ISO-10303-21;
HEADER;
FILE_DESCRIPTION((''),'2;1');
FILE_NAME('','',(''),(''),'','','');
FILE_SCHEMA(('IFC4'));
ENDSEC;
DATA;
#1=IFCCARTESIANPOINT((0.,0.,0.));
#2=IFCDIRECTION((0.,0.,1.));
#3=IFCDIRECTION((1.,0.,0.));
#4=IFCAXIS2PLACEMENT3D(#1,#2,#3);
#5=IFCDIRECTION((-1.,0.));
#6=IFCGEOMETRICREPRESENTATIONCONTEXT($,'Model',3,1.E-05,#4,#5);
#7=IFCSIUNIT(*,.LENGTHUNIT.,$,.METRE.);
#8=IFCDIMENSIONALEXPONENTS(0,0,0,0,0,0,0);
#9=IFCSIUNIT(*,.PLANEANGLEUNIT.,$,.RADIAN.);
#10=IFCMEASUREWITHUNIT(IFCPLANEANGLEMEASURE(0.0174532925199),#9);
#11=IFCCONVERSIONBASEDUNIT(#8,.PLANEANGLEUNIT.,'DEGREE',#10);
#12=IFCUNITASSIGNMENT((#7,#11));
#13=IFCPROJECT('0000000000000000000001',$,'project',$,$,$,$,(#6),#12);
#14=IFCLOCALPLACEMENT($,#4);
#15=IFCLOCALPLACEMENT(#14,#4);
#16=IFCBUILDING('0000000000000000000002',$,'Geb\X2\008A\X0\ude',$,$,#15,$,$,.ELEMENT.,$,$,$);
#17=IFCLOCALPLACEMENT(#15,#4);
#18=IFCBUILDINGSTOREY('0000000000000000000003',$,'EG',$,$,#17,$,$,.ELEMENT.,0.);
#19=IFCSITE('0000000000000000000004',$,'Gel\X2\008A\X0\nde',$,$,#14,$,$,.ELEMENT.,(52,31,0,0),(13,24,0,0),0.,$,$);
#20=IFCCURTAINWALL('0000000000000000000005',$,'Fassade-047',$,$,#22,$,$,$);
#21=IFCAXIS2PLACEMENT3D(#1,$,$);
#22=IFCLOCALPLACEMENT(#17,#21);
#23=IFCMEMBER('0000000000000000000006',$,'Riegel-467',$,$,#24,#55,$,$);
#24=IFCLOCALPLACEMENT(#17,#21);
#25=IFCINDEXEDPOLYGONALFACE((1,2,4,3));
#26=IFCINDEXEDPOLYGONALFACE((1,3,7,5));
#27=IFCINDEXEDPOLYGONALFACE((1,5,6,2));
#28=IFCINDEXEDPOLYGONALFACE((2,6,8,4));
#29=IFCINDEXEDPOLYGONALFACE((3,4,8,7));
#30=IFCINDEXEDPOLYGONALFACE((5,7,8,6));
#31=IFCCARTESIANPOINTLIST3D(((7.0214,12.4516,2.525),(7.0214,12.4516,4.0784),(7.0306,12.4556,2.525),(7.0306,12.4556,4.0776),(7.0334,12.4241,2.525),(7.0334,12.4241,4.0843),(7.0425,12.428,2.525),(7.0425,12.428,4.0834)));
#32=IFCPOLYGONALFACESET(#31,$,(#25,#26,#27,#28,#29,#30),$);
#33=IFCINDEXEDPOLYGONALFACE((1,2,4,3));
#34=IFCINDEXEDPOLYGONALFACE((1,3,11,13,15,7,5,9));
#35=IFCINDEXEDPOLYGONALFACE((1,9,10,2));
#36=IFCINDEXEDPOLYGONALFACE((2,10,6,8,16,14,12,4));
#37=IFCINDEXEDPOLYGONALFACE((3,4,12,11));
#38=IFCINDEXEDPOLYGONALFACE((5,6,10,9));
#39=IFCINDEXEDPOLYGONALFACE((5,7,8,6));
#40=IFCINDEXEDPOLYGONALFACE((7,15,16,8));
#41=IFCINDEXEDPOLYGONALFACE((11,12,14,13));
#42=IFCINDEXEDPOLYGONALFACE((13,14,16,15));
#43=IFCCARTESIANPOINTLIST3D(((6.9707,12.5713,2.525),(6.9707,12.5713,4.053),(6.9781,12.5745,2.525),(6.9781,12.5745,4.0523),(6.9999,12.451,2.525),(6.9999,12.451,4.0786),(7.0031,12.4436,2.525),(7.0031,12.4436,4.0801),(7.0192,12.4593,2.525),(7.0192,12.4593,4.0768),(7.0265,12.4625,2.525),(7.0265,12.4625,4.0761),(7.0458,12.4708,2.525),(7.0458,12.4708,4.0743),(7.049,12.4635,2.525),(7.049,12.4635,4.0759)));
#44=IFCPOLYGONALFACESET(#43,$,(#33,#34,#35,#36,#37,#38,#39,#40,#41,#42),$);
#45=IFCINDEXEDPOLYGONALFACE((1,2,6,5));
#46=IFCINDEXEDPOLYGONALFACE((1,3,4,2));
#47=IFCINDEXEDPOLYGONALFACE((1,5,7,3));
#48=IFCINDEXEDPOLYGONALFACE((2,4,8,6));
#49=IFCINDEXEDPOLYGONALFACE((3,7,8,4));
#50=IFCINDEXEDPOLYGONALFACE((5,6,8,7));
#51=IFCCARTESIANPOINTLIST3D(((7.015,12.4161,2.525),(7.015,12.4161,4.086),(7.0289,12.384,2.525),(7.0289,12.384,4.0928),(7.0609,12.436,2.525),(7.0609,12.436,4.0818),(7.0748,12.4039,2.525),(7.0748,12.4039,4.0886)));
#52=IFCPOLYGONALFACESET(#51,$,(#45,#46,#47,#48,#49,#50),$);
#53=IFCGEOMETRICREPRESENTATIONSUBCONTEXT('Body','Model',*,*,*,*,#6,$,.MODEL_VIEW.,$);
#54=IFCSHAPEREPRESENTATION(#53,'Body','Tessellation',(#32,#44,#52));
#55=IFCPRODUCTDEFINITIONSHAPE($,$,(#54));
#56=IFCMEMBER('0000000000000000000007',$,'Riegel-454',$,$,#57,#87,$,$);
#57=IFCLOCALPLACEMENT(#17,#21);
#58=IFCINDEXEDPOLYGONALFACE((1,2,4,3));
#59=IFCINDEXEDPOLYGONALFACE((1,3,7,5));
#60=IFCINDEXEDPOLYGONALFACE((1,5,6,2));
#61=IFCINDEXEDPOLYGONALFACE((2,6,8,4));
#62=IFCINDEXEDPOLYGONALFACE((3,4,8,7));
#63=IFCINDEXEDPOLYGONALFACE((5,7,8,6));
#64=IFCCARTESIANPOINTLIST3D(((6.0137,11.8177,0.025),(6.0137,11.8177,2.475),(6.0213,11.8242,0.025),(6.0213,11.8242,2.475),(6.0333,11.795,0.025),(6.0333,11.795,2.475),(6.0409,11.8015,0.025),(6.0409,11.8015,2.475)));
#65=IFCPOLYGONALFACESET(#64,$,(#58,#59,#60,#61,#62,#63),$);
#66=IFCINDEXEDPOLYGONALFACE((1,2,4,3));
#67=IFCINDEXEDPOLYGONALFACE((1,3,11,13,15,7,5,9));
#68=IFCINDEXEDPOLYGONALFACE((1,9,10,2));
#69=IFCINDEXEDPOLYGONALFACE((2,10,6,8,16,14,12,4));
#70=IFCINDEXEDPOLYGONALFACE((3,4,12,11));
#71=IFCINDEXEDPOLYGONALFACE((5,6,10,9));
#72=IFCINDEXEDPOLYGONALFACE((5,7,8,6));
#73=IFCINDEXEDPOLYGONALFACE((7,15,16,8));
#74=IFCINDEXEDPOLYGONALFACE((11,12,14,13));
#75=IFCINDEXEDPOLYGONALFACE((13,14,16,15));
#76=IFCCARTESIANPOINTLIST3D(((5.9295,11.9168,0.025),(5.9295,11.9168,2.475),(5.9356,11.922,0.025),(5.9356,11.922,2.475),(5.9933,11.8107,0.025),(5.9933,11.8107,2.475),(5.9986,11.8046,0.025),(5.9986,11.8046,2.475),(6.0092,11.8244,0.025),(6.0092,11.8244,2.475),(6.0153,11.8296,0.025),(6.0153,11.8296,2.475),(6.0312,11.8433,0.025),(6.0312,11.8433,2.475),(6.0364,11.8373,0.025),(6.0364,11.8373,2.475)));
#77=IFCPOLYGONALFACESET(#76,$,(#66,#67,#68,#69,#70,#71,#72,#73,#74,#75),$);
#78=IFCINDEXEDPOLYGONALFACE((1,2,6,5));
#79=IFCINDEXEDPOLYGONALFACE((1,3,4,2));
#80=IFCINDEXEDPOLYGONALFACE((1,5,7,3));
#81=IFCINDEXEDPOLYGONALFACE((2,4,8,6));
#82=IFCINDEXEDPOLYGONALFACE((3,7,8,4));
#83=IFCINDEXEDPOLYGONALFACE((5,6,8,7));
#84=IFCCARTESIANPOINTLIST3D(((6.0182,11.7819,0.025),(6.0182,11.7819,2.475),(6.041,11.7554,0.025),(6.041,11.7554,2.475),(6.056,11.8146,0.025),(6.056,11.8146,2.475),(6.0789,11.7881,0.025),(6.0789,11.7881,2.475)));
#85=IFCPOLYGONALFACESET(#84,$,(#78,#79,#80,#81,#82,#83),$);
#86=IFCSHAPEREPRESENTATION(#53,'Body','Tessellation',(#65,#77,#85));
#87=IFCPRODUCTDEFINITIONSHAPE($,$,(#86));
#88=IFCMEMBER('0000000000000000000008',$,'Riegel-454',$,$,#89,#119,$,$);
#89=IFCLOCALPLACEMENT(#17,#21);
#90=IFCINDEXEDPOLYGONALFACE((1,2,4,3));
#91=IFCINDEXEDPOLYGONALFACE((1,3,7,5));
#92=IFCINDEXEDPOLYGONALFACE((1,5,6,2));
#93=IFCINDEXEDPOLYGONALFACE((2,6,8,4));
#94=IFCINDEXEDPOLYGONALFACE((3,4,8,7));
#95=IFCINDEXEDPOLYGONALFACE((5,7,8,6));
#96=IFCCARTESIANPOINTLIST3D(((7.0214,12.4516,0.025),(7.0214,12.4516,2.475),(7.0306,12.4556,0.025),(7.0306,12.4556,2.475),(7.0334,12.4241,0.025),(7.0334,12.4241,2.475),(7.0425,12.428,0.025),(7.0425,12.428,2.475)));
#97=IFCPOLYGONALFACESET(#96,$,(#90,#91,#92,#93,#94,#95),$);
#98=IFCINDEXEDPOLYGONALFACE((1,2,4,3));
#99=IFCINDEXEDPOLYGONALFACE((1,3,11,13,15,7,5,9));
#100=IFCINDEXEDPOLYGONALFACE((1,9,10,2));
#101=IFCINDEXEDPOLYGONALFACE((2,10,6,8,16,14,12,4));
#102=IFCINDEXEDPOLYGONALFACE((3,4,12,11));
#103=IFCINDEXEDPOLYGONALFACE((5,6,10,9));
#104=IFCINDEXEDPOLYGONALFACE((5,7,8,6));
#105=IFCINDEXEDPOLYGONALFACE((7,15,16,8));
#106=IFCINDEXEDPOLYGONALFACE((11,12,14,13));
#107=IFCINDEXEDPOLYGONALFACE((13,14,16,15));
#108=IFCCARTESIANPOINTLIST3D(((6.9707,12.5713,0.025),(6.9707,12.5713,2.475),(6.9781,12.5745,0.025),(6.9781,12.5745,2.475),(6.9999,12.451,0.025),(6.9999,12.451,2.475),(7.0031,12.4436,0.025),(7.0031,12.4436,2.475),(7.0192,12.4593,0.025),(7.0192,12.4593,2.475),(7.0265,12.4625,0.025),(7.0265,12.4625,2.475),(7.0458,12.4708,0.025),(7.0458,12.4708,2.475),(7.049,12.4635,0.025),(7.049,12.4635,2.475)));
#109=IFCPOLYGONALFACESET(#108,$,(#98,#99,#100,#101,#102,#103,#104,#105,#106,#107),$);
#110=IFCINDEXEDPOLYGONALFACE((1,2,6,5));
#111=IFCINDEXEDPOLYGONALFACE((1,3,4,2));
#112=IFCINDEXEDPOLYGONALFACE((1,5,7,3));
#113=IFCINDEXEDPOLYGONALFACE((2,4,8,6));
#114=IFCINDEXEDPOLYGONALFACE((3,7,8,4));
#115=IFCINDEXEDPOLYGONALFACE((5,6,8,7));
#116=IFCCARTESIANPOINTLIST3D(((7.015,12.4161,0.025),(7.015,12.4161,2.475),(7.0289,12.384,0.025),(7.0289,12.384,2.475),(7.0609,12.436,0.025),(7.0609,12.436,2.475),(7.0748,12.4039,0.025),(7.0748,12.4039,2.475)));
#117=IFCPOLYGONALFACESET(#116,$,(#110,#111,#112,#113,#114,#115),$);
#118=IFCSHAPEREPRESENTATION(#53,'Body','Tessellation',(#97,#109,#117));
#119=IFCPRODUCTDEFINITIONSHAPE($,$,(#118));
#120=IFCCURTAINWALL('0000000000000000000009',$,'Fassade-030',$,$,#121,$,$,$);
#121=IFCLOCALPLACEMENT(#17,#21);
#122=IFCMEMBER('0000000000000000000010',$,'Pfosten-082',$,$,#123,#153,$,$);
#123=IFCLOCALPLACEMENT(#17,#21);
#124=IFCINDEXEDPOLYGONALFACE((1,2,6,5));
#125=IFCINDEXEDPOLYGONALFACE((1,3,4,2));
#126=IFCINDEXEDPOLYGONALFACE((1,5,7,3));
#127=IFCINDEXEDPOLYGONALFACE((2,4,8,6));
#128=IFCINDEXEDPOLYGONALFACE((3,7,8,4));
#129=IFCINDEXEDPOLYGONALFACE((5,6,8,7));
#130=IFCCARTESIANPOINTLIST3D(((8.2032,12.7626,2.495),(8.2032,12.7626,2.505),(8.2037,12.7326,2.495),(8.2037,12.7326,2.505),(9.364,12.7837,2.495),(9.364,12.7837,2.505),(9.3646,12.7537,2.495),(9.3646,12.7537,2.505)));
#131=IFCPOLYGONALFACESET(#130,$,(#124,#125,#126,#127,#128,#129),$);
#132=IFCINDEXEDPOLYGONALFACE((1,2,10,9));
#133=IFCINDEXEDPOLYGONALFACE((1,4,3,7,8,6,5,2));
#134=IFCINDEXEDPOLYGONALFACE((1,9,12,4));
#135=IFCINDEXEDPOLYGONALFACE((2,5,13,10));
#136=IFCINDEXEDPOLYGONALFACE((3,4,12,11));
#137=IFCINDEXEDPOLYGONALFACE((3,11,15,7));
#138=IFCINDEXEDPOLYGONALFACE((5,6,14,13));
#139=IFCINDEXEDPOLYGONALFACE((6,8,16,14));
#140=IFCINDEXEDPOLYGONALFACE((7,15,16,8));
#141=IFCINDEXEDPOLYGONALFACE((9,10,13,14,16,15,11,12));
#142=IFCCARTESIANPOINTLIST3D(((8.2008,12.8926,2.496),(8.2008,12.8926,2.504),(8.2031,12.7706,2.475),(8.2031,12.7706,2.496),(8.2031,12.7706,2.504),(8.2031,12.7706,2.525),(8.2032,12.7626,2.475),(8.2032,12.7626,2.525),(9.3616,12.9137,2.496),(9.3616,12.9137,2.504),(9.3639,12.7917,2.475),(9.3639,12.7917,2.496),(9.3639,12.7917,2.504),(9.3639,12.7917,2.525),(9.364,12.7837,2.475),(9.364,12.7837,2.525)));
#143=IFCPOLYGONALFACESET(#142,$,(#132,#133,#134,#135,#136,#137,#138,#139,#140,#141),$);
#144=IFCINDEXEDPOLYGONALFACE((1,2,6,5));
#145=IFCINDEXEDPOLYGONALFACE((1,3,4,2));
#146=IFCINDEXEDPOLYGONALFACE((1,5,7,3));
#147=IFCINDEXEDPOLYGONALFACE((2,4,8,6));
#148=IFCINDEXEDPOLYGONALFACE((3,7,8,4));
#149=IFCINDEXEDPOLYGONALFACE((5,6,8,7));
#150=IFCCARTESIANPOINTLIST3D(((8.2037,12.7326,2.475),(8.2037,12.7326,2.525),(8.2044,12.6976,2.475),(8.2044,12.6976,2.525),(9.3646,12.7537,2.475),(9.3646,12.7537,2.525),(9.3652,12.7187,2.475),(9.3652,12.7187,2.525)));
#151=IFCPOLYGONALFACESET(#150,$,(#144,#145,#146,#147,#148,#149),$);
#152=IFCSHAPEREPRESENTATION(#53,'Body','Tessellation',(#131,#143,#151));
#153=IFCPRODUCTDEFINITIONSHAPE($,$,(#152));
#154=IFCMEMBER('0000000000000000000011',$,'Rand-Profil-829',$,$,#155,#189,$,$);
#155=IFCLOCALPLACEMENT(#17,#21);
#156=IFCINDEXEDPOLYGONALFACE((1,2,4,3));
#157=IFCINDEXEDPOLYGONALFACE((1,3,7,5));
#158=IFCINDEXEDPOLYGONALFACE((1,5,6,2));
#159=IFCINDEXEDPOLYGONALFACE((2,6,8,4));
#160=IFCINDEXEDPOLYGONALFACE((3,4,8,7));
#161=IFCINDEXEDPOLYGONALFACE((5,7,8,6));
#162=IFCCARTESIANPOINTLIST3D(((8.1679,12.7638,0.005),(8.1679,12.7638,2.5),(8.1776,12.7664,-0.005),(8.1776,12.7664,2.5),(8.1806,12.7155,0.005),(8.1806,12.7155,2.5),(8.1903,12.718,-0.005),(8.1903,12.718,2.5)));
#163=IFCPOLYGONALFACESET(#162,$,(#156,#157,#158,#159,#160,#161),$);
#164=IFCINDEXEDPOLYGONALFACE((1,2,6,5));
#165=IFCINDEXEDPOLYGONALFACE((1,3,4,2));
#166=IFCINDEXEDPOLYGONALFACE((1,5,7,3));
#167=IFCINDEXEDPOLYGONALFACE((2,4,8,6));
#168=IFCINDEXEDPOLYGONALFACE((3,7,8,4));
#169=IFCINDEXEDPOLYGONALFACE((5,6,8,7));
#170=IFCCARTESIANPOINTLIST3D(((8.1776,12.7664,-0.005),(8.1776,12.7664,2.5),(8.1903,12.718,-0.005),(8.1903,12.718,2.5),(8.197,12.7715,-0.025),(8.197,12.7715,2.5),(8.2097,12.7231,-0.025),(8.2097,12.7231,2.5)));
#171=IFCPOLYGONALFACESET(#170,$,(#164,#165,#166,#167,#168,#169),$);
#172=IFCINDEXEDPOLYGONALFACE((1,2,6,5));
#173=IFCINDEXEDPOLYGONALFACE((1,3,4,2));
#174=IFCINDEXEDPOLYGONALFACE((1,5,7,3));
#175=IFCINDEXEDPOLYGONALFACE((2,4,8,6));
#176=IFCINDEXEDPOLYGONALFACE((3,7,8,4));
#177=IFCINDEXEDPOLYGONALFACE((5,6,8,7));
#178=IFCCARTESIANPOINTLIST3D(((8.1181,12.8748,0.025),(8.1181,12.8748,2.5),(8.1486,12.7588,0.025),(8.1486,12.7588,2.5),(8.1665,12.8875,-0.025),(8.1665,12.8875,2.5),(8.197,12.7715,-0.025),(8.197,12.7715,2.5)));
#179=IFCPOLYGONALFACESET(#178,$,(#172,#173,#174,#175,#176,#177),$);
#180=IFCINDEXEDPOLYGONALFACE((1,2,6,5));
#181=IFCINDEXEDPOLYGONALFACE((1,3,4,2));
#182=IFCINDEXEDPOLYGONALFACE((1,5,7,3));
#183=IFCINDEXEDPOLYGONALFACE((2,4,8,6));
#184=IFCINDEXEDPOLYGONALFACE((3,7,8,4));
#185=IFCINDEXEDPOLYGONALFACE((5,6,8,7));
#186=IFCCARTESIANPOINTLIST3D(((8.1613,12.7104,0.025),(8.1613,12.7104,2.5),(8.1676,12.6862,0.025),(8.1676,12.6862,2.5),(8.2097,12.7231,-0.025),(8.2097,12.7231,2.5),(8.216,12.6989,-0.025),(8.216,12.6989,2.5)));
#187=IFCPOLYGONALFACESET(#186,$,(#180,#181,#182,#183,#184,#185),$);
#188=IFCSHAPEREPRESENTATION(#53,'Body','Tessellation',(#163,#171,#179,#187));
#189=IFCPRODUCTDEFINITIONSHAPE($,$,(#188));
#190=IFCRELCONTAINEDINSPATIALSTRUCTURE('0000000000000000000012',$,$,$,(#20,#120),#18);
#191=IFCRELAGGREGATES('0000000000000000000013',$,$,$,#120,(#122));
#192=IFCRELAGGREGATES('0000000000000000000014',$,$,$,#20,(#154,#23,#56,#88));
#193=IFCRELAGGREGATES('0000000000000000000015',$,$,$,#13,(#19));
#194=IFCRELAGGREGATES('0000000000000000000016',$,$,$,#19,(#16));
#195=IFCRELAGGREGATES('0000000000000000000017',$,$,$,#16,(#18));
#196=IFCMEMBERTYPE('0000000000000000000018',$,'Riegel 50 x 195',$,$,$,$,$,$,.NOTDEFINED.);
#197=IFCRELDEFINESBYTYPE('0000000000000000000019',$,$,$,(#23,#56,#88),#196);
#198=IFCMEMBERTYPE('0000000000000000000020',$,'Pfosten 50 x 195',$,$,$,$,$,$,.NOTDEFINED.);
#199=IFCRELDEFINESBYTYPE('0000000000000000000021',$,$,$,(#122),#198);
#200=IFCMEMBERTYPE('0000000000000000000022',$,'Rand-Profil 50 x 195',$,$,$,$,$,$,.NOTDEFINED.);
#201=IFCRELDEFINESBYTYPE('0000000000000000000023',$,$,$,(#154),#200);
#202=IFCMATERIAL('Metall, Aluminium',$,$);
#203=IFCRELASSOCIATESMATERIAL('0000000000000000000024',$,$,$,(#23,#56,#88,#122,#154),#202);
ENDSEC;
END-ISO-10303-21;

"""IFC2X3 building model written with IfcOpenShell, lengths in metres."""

from ifc_helpers import new_model, entity, si_unit, converted_unit, direction, frame, origin_with_axes, place, context, subcontext, project, spatial, polyline, outline, extrude, clip, halfspace, material, type_object, element, aggregate, save


model = new_model("IFC2X3")

# Units and contexts
model_context = context("Model", 3, precision=1e-05, world=origin_with_axes(), true_north=direction((-1.0, 0.0)))
body_context = subcontext(model_context, "Body", "Model", "MODEL_VIEW")
ifc_project = project(units=[si_unit("LENGTHUNIT", "METRE"), converted_unit("PLANEANGLEUNIT", "DEGREE", entity("IfcPlaneAngleMeasure", 0.0174532925199), si_unit("PLANEANGLEUNIT", "RADIAN"), dimensions=[0, 0, 0, 0, 0, 0, 0])], contexts=[model_context])

# Site, building, storey
site_placement = place(None, origin_with_axes())
site = spatial("IfcSite", under=ifc_project, at=site_placement, Name="Gel\u008ande", CompositionType="ELEMENT", RefLatitude=(52, 31, 0, 0), RefLongitude=(13, 24, 0, 0), RefElevation=0.0)
building_placement = place(site_placement, origin_with_axes())
building = spatial("IfcBuilding", under=site, at=building_placement, Name="Geb\u008aude", CompositionType="ELEMENT")
storey_placement = place(building_placement, origin_with_axes())
storey = spatial("IfcBuildingStorey", under=building, at=storey_placement, Name="EG", CompositionType="ELEMENT", Elevation=0.0)

# Curtain wall, members
curtain_wall_1_placement = place(storey_placement, frame((7.6056, 12.5904, 0.0), z_axis=(0.0, 0.0, 1.0), x_axis=(1.0, 0.0, 0.0)))
curtain_wall_1 = element("IfcCurtainWall", 1, at=curtain_wall_1_placement, inside=storey, Name="Fassade-047")
ifc_material_1 = material(Name="Metall, Aluminium")
member_type_1 = type_object("IfcMemberType", Name="Riegel 50 x 195", PredefinedType="NOTDEFINED")
member_1_placement = place(curtain_wall_1_placement, frame((-0.5736, -0.1506, 2.5), z_axis=(0.0, 0.0, 1.0), x_axis=(0.917733, 0.397197, 0.0)))
member_1 = element("IfcMember", 2, at=member_1_placement, type_object=member_type_1, material=ifc_material_1, Name="Riegel-467", context=body_context, shape_type="Clipping", body=[
    clip(extrude(outline(polyline([(0.0105, -0.0118), (-0.0014, 0.0158), (-0.0105, 0.0118), (0.0014, -0.0158), (0.0105, -0.0118)])), frame((0.0, 0.0, 0.025), z_axis=(0.0, 0.0, 1.0), x_axis=(0.917733, -0.397197, 0.0)), (0.0, 0.0, 1.0), 1.5593), halfspace(frame((0.1277, 0.2951, 1.5126), z_axis=(-0.082582, -0.190807, -0.978148), x_axis=(0.0, -0.9815, 0.191461)), True)),
    clip(extrude(outline(polyline([(0.017, 0.0237), (0.0138, 0.031), (-0.0055, 0.0227), (-0.0539, 0.1347), (-0.0613, 0.1315), (-0.0128, 0.0195), (-0.0321, 0.0112), (-0.0289, 0.0038), (0.017, 0.0237)])), frame((0.0, 0.0, 0.025), z_axis=(0.0, 0.0, 1.0), x_axis=(0.917733, -0.397197, 0.0)), (0.0, 0.0, 1.0), 1.5551), halfspace(frame((0.1277, 0.2951, 1.5126), z_axis=(-0.082582, -0.190807, -0.978148), x_axis=(0.0, -0.9815, 0.191461)), True)),
    clip(extrude(outline(polyline([(0.0428, -0.036), (0.0289, -0.0038), (-0.017, -0.0237), (-0.0031, -0.0558), (0.0428, -0.036)])), frame((0.0, 0.0, 0.025), z_axis=(0.0, 0.0, 1.0), x_axis=(0.917733, -0.397197, 0.0)), (0.0, 0.0, 1.0), 1.5678), halfspace(frame((0.1277, 0.2951, 1.5126), z_axis=(-0.082582, -0.190807, -0.978148), x_axis=(0.0, -0.9815, 0.191461)), True)),
])
member_2_placement = place(curtain_wall_1_placement, frame((-1.5783, -0.7808, 0.0), z_axis=(0.0, 0.0, 1.0), x_axis=(0.757068, 0.653336, 0.0)))
member_2 = element("IfcMember", 3, at=member_2_placement, type_object=member_type_1, material=ifc_material_1, Name="Riegel-454", context=body_context, shape_type="SweptSolid", body=[
    extrude(outline(polyline([(-0.006, 0.0146), (-0.0136, 0.0081), (0.006, -0.0146), (0.0136, -0.0081), (-0.006, 0.0146)])), frame((0.0, 0.0, 0.025), z_axis=(0.0, 0.0, 1.0), x_axis=(0.757068, -0.653336, 0.0)), (0.0, 0.0, 1.0), 2.45),
    extrude(outline(polyline([(-0.0917, 0.1124), (-0.0978, 0.1072), (-0.0181, 0.0148), (-0.034, 0.0011), (-0.0287, -0.005), (0.0091, 0.0277), (0.0039, 0.0337), (-0.012, 0.02), (-0.0917, 0.1124)])), frame((0.0, 0.0, 0.025), z_axis=(0.0, 0.0, 1.0), x_axis=(0.757068, -0.653336, 0.0)), (0.0, 0.0, 1.0), 2.45),
    extrude(outline(polyline([(0.0137, -0.0542), (0.0516, -0.0215), (0.0287, 0.005), (-0.0091, -0.0277), (0.0137, -0.0542)])), frame((0.0, 0.0, 0.025), z_axis=(0.0, 0.0, 1.0), x_axis=(0.757068, -0.653336, 0.0)), (0.0, 0.0, 1.0), 2.45),
])
member_3_placement = place(curtain_wall_1_placement, frame((-0.5736, -0.1506, 0.0), z_axis=(0.0, 0.0, 1.0), x_axis=(0.917733, 0.397197, 0.0)))
member_3 = element("IfcMember", 4, at=member_3_placement, type_object=member_type_1, material=ifc_material_1, Name="Riegel-454", context=body_context, shape_type="SweptSolid", body=[
    extrude(outline(polyline([(-0.0014, 0.0158), (-0.0105, 0.0118), (0.0014, -0.0158), (0.0105, -0.0118), (-0.0014, 0.0158)])), frame((0.0, 0.0, 0.025), z_axis=(0.0, 0.0, 1.0), x_axis=(0.917733, -0.397197, 0.0)), (0.0, 0.0, 1.0), 2.45),
    extrude(outline(polyline([(-0.0539, 0.1347), (-0.0613, 0.1315), (-0.0128, 0.0195), (-0.0321, 0.0112), (-0.0289, 0.0038), (0.017, 0.0237), (0.0138, 0.031), (-0.0055, 0.0227), (-0.0539, 0.1347)])), frame((0.0, 0.0, 0.025), z_axis=(0.0, 0.0, 1.0), x_axis=(0.917733, -0.397197, 0.0)), (0.0, 0.0, 1.0), 2.45),
    extrude(outline(polyline([(-0.0031, -0.0558), (0.0428, -0.036), (0.0289, -0.0038), (-0.017, -0.0237), (-0.0031, -0.0558)])), frame((0.0, 0.0, 0.025), z_axis=(0.0, 0.0, 1.0), x_axis=(0.917733, -0.397197, 0.0)), (0.0, 0.0, 1.0), 2.45),
])

# Curtain wall, member
curtain_wall_2_placement = place(storey_placement, frame((8.7714, 12.7579, 0.0), z_axis=(0.0, 0.0, 1.0), x_axis=(1.0, 0.0, 0.0)))
curtain_wall_2 = element("IfcCurtainWall", 5, at=curtain_wall_2_placement, inside=storey, Name="Fassade-030")
member_type_2 = type_object("IfcMemberType", Name="Pfosten 50 x 195", PredefinedType="NOTDEFINED")
member_4_placement = place(curtain_wall_2_placement, frame((-0.5929, -0.0108, 2.5), z_axis=(0.999835, 0.018178, 0.0), x_axis=(0.0, 0.0, 1.0)))
member_4 = element("IfcMember", 6, at=member_4_placement, type_object=member_type_2, material=ifc_material_1, Name="Pfosten-082", context=body_context, shape_type="SweptSolid", body=[
    extrude(outline(polyline([(-0.015, -0.005), (0.015, -0.005), (0.015, 0.005), (-0.015, 0.005), (-0.015, -0.005)])), frame((0.0, 0.0, 0.025), z_axis=(0.0, 0.0, 1.0), x_axis=(0.0, 1.0, 0.0)), (0.0, 0.0, 1.0), 1.161),
    extrude(outline(polyline([(-0.145, -0.004), (-0.023, -0.004), (-0.023, -0.025), (-0.015, -0.025), (-0.015, 0.025), (-0.023, 0.025), (-0.023, 0.004), (-0.145, 0.004), (-0.145, -0.004)])), frame((0.0, 0.0, 0.025), z_axis=(0.0, 0.0, 1.0), x_axis=(0.0, 1.0, 0.0)), (0.0, 0.0, 1.0), 1.161),
    extrude(outline(polyline([(0.05, 0.025), (0.015, 0.025), (0.015, -0.025), (0.05, -0.025), (0.05, 0.025)])), frame((0.0, 0.0, 0.025), z_axis=(0.0, 0.0, 1.0), x_axis=(0.0, 1.0, 0.0)), (0.0, 0.0, 1.0), 1.161),
])
aggregate(curtain_wall_2, [member_4])

# Member
member_type_3 = type_object("IfcMemberType", Name="Rand-Profil 50 x 195", PredefinedType="NOTDEFINED")
member_5_placement = place(curtain_wall_1_placement, frame((0.5736, 0.1506, 0.0), z_axis=(0.0, 0.0, 1.0), x_axis=(0.967233, 0.25389, 0.0)))
member_5 = element("IfcMember", 7, at=member_5_placement, type_object=member_type_3, material=ifc_material_1, Name="Rand-Profil-829", context=body_context, shape_type="Clipping", body=[
    clip(extrude(outline(polyline([(-0.0015, 0.0255), (-0.0112, 0.0229), (0.0015, -0.0255), (0.0112, -0.0229), (-0.0015, 0.0255)])), frame((0.0, 0.0, -0.005), z_axis=(0.0, 0.0, 1.0), x_axis=(0.967233, -0.25389, 0.0)), (0.0, 0.0, 1.0), 2.505), halfspace(frame((0.0, 0.0, 0.0), z_axis=(0.707107, 0.0, 0.707107), x_axis=(-0.707107, 0.0, 0.707107)), True)),
    clip(extrude(outline(polyline([(0.0178, 0.0305), (-0.0015, 0.0255), (0.0112, -0.0229), (0.0305, -0.0178), (0.0178, 0.0305)])), frame((0.0, 0.0, -0.025), z_axis=(0.0, 0.0, 1.0), x_axis=(0.967233, -0.25389, 0.0)), (0.0, 0.0, 1.0), 2.525), halfspace(frame((0.0, 0.0, 0.0), z_axis=(0.707107, 0.0, 0.707107), x_axis=(-0.707107, 0.0, 0.707107)), True)),
    clip(extrude(outline(polyline([(-0.0126, 0.1466), (-0.061, 0.1339), (-0.0305, 0.0178), (0.0178, 0.0305), (-0.0126, 0.1466)])), frame((0.0, 0.0, -0.025), z_axis=(0.0, 0.0, 1.0), x_axis=(0.967233, -0.25389, 0.0)), (0.0, 0.0, 1.0), 2.525), halfspace(frame((0.0, 0.0, 0.0), z_axis=(0.707107, 0.0, 0.707107), x_axis=(-0.707107, 0.0, 0.707107)), True)),
    clip(extrude(outline(polyline([(-0.0115, -0.0547), (0.0369, -0.042), (0.0305, -0.0178), (-0.0178, -0.0305), (-0.0115, -0.0547)])), frame((0.0, 0.0, -0.025), z_axis=(0.0, 0.0, 1.0), x_axis=(0.967233, -0.25389, 0.0)), (0.0, 0.0, 1.0), 2.525), halfspace(frame((0.0, 0.0, 0.0), z_axis=(0.707107, 0.0, 0.707107), x_axis=(-0.707107, 0.0, 0.707107)), True)),
])

aggregate(curtain_wall_1, [member_5, member_1, member_2, member_3])

save(model, "model.ifc")
